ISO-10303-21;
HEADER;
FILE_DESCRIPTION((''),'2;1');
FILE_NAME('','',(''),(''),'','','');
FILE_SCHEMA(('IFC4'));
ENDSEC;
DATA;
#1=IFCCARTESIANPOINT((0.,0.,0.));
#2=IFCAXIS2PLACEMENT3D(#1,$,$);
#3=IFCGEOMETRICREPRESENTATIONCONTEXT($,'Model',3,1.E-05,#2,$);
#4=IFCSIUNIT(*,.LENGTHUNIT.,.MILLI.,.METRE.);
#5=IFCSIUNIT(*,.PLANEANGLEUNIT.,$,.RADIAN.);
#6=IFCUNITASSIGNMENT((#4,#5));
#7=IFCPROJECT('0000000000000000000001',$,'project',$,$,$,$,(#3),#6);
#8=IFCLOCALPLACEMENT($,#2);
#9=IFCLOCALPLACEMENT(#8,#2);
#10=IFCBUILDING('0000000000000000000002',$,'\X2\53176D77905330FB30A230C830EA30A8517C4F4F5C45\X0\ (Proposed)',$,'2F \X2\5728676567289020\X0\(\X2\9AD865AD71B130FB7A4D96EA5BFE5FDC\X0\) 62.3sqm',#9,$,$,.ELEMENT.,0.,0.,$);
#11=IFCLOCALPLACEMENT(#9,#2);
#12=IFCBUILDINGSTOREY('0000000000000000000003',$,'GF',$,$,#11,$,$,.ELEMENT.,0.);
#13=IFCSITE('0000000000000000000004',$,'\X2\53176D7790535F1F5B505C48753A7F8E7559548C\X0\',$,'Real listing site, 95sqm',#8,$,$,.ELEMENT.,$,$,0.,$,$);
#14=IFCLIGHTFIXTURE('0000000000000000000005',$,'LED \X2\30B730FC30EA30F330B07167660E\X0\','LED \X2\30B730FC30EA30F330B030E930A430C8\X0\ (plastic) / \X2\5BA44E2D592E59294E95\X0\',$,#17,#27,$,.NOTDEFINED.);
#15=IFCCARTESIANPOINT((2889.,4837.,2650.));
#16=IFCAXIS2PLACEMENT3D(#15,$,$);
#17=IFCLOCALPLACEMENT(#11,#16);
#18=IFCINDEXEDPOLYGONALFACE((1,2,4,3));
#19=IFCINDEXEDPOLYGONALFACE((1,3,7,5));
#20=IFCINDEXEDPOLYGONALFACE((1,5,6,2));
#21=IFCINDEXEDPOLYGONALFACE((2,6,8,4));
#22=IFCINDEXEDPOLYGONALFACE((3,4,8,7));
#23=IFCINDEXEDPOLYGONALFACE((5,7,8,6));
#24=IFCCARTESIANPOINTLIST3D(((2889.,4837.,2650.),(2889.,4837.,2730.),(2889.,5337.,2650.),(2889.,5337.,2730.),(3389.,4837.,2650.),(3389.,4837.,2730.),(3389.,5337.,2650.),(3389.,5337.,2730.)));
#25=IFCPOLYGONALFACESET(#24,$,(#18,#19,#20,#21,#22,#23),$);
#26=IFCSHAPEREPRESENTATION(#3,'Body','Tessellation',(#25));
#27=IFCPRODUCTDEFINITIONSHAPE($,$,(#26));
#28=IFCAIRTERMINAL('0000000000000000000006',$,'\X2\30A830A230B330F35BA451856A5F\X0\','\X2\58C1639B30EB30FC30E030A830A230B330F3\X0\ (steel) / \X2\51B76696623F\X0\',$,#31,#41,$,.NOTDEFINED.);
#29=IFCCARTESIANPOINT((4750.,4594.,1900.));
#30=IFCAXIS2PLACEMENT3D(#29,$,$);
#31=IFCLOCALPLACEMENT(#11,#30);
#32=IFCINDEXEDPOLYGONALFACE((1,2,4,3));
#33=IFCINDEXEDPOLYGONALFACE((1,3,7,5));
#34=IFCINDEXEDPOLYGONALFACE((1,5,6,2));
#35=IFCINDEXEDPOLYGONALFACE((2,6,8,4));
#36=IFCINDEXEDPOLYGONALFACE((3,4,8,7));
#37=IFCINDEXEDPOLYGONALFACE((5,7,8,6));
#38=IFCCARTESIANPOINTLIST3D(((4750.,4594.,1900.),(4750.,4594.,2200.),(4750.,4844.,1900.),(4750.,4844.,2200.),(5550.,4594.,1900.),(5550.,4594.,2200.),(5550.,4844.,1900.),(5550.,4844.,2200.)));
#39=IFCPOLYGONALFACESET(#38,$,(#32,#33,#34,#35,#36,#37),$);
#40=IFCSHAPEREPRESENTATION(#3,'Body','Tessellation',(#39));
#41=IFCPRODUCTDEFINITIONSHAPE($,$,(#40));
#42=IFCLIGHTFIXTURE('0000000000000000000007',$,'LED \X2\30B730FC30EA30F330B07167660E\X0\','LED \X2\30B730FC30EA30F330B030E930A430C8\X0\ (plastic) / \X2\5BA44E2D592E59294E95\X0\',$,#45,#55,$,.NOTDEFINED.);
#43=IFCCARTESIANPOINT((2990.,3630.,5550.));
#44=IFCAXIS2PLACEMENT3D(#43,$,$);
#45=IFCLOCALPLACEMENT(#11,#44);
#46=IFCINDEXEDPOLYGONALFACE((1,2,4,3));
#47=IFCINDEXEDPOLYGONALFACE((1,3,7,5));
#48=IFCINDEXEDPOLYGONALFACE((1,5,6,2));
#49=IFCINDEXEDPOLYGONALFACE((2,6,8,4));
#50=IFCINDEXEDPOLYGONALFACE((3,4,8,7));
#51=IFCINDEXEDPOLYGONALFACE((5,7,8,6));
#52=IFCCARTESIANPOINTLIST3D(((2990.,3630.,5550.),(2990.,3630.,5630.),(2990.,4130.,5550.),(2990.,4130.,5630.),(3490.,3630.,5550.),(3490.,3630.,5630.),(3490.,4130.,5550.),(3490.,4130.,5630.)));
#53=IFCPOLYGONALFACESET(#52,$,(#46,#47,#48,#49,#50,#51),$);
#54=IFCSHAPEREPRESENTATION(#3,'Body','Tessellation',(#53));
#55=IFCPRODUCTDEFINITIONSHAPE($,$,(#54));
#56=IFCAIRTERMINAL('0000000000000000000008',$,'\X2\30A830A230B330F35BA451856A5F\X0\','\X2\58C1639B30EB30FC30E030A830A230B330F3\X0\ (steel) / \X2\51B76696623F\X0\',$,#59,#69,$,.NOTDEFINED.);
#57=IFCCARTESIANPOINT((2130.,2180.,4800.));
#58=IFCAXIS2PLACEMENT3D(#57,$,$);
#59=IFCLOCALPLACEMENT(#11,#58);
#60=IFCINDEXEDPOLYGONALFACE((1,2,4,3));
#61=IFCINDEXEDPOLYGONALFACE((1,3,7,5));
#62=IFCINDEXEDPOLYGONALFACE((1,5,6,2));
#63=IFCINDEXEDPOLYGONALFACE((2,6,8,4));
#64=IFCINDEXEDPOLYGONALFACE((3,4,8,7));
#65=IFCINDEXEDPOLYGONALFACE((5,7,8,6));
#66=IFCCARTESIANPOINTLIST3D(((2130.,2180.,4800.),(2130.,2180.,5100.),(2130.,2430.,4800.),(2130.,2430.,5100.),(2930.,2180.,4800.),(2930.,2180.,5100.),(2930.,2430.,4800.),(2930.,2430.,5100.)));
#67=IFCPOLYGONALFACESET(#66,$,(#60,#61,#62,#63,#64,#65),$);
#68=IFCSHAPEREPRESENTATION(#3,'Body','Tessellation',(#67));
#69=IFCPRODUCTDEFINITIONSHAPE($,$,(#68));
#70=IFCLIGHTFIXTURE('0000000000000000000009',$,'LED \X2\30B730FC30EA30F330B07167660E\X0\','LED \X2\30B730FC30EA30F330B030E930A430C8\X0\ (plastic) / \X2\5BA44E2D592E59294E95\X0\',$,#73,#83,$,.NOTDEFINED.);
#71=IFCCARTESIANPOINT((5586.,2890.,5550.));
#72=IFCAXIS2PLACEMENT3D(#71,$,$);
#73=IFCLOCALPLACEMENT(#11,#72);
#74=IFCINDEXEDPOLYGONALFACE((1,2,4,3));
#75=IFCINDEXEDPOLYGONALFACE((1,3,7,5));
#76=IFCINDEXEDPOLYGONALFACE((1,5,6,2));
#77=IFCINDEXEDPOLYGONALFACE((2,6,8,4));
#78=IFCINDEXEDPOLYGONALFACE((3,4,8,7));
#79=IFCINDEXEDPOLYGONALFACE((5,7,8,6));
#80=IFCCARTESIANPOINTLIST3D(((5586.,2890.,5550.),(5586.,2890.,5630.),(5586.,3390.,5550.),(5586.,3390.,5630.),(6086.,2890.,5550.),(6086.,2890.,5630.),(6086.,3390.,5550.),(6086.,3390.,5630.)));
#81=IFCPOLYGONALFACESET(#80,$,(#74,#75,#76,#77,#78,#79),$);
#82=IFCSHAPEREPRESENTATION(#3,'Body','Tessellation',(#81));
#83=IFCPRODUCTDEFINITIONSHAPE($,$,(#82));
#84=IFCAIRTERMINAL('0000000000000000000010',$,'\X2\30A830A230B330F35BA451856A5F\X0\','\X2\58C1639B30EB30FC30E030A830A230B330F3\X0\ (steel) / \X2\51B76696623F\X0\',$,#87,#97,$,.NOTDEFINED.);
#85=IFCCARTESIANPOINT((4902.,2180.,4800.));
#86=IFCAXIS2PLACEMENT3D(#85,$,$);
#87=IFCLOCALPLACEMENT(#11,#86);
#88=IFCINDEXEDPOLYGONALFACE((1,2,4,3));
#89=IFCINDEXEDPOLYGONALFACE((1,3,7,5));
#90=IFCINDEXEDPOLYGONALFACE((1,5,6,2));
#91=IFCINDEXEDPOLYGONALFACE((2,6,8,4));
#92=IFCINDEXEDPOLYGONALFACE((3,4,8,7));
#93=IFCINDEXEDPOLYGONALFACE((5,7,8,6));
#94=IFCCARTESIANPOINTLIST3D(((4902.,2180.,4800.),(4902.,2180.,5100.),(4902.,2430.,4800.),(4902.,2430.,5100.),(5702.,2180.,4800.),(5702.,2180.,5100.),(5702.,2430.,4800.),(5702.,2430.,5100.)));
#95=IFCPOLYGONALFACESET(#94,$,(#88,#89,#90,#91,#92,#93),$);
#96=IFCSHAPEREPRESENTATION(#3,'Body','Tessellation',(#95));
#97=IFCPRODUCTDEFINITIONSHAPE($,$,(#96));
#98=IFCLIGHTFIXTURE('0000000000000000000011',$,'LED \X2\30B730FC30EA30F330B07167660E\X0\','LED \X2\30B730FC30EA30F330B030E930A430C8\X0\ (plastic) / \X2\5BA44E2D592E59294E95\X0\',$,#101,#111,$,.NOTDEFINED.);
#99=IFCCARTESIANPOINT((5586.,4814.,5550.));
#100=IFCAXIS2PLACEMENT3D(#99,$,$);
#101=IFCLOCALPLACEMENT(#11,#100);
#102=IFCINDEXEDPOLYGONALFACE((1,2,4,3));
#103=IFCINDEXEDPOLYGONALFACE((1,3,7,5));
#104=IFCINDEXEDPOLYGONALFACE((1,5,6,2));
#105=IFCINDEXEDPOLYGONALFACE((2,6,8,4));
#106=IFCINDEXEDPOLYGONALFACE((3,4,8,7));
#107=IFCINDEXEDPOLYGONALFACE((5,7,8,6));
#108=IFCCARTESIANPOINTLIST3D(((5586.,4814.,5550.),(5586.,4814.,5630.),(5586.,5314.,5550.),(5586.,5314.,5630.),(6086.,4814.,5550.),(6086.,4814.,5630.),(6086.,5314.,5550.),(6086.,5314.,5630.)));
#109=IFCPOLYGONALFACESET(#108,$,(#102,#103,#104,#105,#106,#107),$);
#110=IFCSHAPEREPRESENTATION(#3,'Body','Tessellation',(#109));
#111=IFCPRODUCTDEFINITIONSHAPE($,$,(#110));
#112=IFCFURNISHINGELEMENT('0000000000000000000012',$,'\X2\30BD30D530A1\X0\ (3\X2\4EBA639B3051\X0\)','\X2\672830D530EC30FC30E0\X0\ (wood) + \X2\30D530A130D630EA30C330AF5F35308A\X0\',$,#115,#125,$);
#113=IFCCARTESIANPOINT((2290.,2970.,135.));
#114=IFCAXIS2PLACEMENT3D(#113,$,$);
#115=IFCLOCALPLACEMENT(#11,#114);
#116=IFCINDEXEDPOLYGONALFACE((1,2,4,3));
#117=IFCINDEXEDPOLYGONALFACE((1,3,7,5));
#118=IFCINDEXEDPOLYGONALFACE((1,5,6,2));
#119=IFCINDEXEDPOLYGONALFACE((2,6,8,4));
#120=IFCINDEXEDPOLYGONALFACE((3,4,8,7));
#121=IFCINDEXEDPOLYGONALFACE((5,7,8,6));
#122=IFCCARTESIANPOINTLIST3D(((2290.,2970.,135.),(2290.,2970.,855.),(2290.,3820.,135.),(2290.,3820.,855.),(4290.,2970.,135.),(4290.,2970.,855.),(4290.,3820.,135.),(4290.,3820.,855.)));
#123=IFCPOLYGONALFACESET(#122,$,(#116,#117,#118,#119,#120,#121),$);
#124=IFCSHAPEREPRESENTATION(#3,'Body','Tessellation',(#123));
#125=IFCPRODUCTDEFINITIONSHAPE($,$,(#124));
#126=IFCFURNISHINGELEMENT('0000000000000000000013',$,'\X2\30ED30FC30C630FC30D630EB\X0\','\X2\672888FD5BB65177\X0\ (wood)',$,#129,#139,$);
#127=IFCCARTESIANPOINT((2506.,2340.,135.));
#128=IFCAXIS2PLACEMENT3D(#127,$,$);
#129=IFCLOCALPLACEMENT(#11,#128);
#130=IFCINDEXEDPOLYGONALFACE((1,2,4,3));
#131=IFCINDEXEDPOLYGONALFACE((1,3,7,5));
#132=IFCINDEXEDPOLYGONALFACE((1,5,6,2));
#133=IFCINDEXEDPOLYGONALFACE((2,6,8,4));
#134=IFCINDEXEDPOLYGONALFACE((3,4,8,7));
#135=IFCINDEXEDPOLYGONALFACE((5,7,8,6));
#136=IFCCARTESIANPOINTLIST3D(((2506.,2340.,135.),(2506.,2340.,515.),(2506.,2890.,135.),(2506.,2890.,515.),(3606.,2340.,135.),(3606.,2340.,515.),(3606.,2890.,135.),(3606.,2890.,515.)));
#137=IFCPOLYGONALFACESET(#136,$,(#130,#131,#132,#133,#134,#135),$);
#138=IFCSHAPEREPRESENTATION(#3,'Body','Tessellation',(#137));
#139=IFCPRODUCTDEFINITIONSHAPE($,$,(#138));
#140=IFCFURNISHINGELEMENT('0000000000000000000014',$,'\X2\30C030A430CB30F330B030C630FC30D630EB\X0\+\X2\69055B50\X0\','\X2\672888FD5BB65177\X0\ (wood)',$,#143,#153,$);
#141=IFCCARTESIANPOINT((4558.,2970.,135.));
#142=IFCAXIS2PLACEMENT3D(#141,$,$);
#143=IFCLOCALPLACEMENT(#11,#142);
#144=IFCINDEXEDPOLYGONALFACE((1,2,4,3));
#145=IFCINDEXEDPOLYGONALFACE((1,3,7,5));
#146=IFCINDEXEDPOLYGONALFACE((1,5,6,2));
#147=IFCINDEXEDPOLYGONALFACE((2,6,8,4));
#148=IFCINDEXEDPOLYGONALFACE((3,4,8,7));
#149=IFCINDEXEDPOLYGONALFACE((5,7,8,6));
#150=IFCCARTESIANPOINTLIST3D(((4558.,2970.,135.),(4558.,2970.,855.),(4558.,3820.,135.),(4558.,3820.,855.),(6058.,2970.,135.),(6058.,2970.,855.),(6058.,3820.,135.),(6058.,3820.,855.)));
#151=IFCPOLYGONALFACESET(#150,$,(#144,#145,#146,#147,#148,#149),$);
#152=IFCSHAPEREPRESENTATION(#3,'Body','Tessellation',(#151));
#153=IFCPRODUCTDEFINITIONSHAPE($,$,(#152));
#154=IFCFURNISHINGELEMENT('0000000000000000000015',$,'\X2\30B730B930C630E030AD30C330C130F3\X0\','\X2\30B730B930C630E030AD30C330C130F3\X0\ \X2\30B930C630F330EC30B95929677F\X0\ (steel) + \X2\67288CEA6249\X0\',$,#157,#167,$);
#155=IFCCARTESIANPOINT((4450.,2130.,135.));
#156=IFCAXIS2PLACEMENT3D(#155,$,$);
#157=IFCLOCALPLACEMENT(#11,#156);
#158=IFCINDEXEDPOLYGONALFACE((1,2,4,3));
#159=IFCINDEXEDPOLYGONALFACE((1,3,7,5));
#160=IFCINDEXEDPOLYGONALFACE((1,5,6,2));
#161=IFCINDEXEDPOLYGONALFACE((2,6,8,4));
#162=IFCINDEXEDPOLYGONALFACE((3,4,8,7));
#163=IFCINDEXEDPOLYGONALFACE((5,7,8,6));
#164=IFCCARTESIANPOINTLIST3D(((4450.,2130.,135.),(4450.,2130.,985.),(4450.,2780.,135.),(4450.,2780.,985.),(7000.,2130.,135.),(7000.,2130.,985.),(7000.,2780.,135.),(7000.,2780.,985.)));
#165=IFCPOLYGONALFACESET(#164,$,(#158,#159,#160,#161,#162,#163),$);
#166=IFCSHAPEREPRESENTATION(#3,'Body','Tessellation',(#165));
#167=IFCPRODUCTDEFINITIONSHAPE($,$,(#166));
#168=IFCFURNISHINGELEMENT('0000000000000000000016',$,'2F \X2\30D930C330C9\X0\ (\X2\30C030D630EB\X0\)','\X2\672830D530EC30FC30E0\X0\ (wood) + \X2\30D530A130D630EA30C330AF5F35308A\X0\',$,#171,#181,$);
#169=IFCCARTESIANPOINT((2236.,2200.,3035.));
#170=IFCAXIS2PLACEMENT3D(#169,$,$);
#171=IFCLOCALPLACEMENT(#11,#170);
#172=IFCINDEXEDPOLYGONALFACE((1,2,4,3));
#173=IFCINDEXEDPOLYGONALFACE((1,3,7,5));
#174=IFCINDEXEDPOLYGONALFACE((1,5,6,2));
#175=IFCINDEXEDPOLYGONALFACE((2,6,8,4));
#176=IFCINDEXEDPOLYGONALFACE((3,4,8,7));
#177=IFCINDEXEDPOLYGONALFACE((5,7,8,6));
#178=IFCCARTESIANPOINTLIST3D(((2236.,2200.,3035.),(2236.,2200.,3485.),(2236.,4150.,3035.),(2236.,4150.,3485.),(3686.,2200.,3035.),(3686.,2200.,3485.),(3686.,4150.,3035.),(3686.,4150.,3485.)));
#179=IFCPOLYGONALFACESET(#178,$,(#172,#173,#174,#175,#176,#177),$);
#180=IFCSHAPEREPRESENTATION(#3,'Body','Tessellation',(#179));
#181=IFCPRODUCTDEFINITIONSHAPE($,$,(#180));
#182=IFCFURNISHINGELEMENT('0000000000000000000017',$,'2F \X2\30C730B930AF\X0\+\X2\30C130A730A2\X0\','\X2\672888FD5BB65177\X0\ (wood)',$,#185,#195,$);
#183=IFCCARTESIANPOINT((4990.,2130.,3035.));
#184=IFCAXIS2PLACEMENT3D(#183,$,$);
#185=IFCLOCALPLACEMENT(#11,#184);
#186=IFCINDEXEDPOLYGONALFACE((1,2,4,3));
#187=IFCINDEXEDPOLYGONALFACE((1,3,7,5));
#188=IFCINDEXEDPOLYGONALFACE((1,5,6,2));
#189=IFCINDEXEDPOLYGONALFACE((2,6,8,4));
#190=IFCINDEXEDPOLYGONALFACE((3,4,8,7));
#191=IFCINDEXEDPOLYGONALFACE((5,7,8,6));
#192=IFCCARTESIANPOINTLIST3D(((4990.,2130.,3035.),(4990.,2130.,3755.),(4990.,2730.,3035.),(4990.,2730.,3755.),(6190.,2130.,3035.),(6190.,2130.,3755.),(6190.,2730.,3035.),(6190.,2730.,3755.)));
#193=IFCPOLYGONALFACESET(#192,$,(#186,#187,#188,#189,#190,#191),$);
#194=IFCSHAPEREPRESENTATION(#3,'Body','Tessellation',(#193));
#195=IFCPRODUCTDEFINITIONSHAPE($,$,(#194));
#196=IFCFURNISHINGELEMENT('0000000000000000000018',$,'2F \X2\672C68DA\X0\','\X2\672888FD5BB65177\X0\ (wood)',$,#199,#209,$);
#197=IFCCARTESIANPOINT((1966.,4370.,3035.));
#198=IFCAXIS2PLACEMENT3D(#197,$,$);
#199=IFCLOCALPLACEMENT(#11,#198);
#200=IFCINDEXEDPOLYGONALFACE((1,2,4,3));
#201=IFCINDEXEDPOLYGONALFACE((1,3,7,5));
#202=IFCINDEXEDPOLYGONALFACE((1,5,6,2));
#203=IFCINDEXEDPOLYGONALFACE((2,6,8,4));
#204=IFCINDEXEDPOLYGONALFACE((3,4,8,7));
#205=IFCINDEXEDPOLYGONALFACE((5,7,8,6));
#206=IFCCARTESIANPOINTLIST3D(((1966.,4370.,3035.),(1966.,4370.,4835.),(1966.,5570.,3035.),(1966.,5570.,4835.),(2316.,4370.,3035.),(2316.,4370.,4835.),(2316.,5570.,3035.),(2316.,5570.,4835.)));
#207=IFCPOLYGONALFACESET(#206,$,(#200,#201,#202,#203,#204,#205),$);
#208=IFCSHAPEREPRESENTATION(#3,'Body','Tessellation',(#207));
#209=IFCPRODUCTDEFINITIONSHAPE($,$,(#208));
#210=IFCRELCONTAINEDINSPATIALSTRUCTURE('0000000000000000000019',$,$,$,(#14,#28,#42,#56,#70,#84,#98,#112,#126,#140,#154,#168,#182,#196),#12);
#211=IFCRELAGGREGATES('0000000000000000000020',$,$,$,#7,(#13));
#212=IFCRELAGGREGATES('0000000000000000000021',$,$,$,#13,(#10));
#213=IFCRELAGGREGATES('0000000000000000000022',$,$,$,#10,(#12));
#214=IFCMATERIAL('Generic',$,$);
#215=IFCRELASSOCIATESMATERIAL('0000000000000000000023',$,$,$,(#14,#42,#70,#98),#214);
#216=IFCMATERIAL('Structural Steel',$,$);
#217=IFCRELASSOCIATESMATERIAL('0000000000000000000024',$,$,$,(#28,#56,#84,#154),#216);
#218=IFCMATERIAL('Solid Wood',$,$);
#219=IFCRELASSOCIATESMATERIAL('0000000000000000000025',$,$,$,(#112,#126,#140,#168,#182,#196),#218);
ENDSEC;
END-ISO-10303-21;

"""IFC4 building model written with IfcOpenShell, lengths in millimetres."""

from ifc_helpers import new_model, si_unit, frame, frame_2d, origin, place, context, project, spatial, rectangle, extrude, material, element, save


model = new_model("IFC4")

# Units and contexts
model_context = context("Model", 3, precision=1e-05, world=origin())
ifc_project = project(units=[si_unit("LENGTHUNIT", "METRE", prefix="MILLI"), si_unit("PLANEANGLEUNIT", "RADIAN")], contexts=[model_context])

# Site, building, storey
site_placement = place(None, origin())
site = spatial("IfcSite", under=ifc_project, at=site_placement, Name="北海道弟子屈町美留和", ObjectType="Real listing site, 95sqm", CompositionType="ELEMENT", RefElevation=0.0)
building_placement = place(site_placement, origin())
building = spatial("IfcBuilding", under=site, at=building_placement, Name="北海道・アトリエ兼住居 (Proposed)", ObjectType="2F 在来木造(高断熱・積雪対応) 62.3sqm", CompositionType="ELEMENT", ElevationOfRefHeight=0.0, ElevationOfTerrain=0.0)
storey_placement = place(building_placement, origin())
storey = spatial("IfcBuildingStorey", under=building, at=storey_placement, Name="GF", CompositionType="ELEMENT", Elevation=0.0)

# Shared definitions
ifc_material_1 = material(Name="Solid Wood")

# Shared definitions
ifc_material_2 = material(Name="Structural Steel")

# Shared definitions
ifc_material_3 = material(Name="Generic")

# Light fixture
light_fixture_1_placement = place(storey_placement, frame((2889.0, 4837.0, 2650.0)))
element("IfcLightFixture", 1, at=light_fixture_1_placement, inside=storey, material=ifc_material_3, Name="LED シーリング照明", Description="LED シーリングライト (plastic) / 室中央天井", PredefinedType="NOTDEFINED", context=model_context, shape_type="SweptSolid", body=[
    extrude(rectangle(XDim=500.0, YDim=500.0, at=frame_2d((250.0, 250.0))), frame((2889.0, 4837.0, 2650.0)), (0.0, 0.0, 1.0), 80.0),
])

# Air terminal
air_terminal_1_placement = place(storey_placement, frame((4750.0, 4594.0, 1900.0)))
element("IfcAirTerminal", 2, at=air_terminal_1_placement, inside=storey, material=ifc_material_2, Name="エアコン室内機", Description="壁掛ルームエアコン (steel) / 冷暖房", PredefinedType="NOTDEFINED", context=model_context, shape_type="SweptSolid", body=[
    extrude(rectangle(XDim=800.0, YDim=250.0, at=frame_2d((400.0, 125.0))), frame((4750.0, 4594.0, 1900.0)), (0.0, 0.0, 1.0), 300.0),
])

# Light fixture
light_fixture_2_placement = place(storey_placement, frame((2990.0, 3630.0, 5550.0)))
element("IfcLightFixture", 3, at=light_fixture_2_placement, inside=storey, material=ifc_material_3, Name="LED シーリング照明", Description="LED シーリングライト (plastic) / 室中央天井", PredefinedType="NOTDEFINED", context=model_context, shape_type="SweptSolid", body=[
    extrude(rectangle(XDim=500.0, YDim=500.0, at=frame_2d((250.0, 250.0))), frame((2990.0, 3630.0, 5550.0)), (0.0, 0.0, 1.0), 80.0),
])

# Air terminal
air_terminal_2_placement = place(storey_placement, frame((2130.0, 2180.0, 4800.0)))
element("IfcAirTerminal", 4, at=air_terminal_2_placement, inside=storey, material=ifc_material_2, Name="エアコン室内機", Description="壁掛ルームエアコン (steel) / 冷暖房", PredefinedType="NOTDEFINED", context=model_context, shape_type="SweptSolid", body=[
    extrude(rectangle(XDim=800.0, YDim=250.0, at=frame_2d((400.0, 125.0))), frame((2130.0, 2180.0, 4800.0)), (0.0, 0.0, 1.0), 300.0),
])

# Light fixture
light_fixture_3_placement = place(storey_placement, frame((5586.0, 2890.0, 5550.0)))
element("IfcLightFixture", 5, at=light_fixture_3_placement, inside=storey, material=ifc_material_3, Name="LED シーリング照明", Description="LED シーリングライト (plastic) / 室中央天井", PredefinedType="NOTDEFINED", context=model_context, shape_type="SweptSolid", body=[
    extrude(rectangle(XDim=500.0, YDim=500.0, at=frame_2d((250.0, 250.0))), frame((5586.0, 2890.0, 5550.0)), (0.0, 0.0, 1.0), 80.0),
])

# Air terminal
air_terminal_3_placement = place(storey_placement, frame((4902.0, 2180.0, 4800.0)))
element("IfcAirTerminal", 6, at=air_terminal_3_placement, inside=storey, material=ifc_material_2, Name="エアコン室内機", Description="壁掛ルームエアコン (steel) / 冷暖房", PredefinedType="NOTDEFINED", context=model_context, shape_type="SweptSolid", body=[
    extrude(rectangle(XDim=800.0, YDim=250.0, at=frame_2d((400.0, 125.0))), frame((4902.0, 2180.0, 4800.0)), (0.0, 0.0, 1.0), 300.0),
])

# Light fixture
light_fixture_4_placement = place(storey_placement, frame((5586.0, 4814.0, 5550.0)))
element("IfcLightFixture", 7, at=light_fixture_4_placement, inside=storey, material=ifc_material_3, Name="LED シーリング照明", Description="LED シーリングライト (plastic) / 室中央天井", PredefinedType="NOTDEFINED", context=model_context, shape_type="SweptSolid", body=[
    extrude(rectangle(XDim=500.0, YDim=500.0, at=frame_2d((250.0, 250.0))), frame((5586.0, 4814.0, 5550.0)), (0.0, 0.0, 1.0), 80.0),
])

# Furnishing elements
furnishing_1_placement = place(storey_placement, frame((2290.0, 2970.0, 135.0)))
element("IfcFurnishingElement", 8, at=furnishing_1_placement, inside=storey, material=ifc_material_1, Name="ソファ (3人掛け)", Description="木フレーム (wood) + ファブリック張り", context=model_context, shape_type="SweptSolid", body=[
    extrude(rectangle(XDim=2000.0, YDim=850.0, at=frame_2d((1000.0, 425.0))), frame((2290.0, 2970.0, 135.0)), (0.0, 0.0, 1.0), 720.0),
])
furnishing_2_placement = place(storey_placement, frame((2506.0, 2340.0, 135.0)))
element("IfcFurnishingElement", 9, at=furnishing_2_placement, inside=storey, material=ifc_material_1, Name="ローテーブル", Description="木製家具 (wood)", context=model_context, shape_type="SweptSolid", body=[
    extrude(rectangle(XDim=1100.0, YDim=550.0, at=frame_2d((550.0, 275.0))), frame((2506.0, 2340.0, 135.0)), (0.0, 0.0, 1.0), 380.0),
])
furnishing_3_placement = place(storey_placement, frame((4558.0, 2970.0, 135.0)))
element("IfcFurnishingElement", 10, at=furnishing_3_placement, inside=storey, material=ifc_material_1, Name="ダイニングテーブル+椅子", Description="木製家具 (wood)", context=model_context, shape_type="SweptSolid", body=[
    extrude(rectangle(XDim=1500.0, YDim=850.0, at=frame_2d((750.0, 425.0))), frame((4558.0, 2970.0, 135.0)), (0.0, 0.0, 1.0), 720.0),
])
furnishing_4_placement = place(storey_placement, frame((4450.0, 2130.0, 135.0)))
element("IfcFurnishingElement", 11, at=furnishing_4_placement, inside=storey, material=ifc_material_2, Name="システムキッチン", Description="システムキッチン ステンレス天板 (steel) + 木質扉", context=model_context, shape_type="SweptSolid", body=[
    extrude(rectangle(XDim=2550.0, YDim=650.0, at=frame_2d((1275.0, 325.0))), frame((4450.0, 2130.0, 135.0)), (0.0, 0.0, 1.0), 850.0),
])
furnishing_5_placement = place(storey_placement, frame((2236.0, 2200.0, 3035.0)))
element("IfcFurnishingElement", 12, at=furnishing_5_placement, inside=storey, material=ifc_material_1, Name="2F ベッド (ダブル)", Description="木フレーム (wood) + ファブリック張り", context=model_context, shape_type="SweptSolid", body=[
    extrude(rectangle(XDim=1450.0, YDim=1950.0, at=frame_2d((725.0, 975.0))), frame((2236.0, 2200.0, 3035.0)), (0.0, 0.0, 1.0), 450.0),
])
furnishing_6_placement = place(storey_placement, frame((4990.0, 2130.0, 3035.0)))
element("IfcFurnishingElement", 13, at=furnishing_6_placement, inside=storey, material=ifc_material_1, Name="2F デスク+チェア", Description="木製家具 (wood)", context=model_context, shape_type="SweptSolid", body=[
    extrude(rectangle(XDim=1200.0, YDim=600.0, at=frame_2d((600.0, 300.0))), frame((4990.0, 2130.0, 3035.0)), (0.0, 0.0, 1.0), 720.0),
])
furnishing_7_placement = place(storey_placement, frame((1966.0, 4370.0, 3035.0)))
element("IfcFurnishingElement", 14, at=furnishing_7_placement, inside=storey, material=ifc_material_1, Name="2F 本棚", Description="木製家具 (wood)", context=model_context, shape_type="SweptSolid", body=[
    extrude(rectangle(XDim=350.0, YDim=1200.0, at=frame_2d((175.0, 600.0))), frame((1966.0, 4370.0, 3035.0)), (0.0, 0.0, 1.0), 1800.0),
])

save(model, "model.ifc")
